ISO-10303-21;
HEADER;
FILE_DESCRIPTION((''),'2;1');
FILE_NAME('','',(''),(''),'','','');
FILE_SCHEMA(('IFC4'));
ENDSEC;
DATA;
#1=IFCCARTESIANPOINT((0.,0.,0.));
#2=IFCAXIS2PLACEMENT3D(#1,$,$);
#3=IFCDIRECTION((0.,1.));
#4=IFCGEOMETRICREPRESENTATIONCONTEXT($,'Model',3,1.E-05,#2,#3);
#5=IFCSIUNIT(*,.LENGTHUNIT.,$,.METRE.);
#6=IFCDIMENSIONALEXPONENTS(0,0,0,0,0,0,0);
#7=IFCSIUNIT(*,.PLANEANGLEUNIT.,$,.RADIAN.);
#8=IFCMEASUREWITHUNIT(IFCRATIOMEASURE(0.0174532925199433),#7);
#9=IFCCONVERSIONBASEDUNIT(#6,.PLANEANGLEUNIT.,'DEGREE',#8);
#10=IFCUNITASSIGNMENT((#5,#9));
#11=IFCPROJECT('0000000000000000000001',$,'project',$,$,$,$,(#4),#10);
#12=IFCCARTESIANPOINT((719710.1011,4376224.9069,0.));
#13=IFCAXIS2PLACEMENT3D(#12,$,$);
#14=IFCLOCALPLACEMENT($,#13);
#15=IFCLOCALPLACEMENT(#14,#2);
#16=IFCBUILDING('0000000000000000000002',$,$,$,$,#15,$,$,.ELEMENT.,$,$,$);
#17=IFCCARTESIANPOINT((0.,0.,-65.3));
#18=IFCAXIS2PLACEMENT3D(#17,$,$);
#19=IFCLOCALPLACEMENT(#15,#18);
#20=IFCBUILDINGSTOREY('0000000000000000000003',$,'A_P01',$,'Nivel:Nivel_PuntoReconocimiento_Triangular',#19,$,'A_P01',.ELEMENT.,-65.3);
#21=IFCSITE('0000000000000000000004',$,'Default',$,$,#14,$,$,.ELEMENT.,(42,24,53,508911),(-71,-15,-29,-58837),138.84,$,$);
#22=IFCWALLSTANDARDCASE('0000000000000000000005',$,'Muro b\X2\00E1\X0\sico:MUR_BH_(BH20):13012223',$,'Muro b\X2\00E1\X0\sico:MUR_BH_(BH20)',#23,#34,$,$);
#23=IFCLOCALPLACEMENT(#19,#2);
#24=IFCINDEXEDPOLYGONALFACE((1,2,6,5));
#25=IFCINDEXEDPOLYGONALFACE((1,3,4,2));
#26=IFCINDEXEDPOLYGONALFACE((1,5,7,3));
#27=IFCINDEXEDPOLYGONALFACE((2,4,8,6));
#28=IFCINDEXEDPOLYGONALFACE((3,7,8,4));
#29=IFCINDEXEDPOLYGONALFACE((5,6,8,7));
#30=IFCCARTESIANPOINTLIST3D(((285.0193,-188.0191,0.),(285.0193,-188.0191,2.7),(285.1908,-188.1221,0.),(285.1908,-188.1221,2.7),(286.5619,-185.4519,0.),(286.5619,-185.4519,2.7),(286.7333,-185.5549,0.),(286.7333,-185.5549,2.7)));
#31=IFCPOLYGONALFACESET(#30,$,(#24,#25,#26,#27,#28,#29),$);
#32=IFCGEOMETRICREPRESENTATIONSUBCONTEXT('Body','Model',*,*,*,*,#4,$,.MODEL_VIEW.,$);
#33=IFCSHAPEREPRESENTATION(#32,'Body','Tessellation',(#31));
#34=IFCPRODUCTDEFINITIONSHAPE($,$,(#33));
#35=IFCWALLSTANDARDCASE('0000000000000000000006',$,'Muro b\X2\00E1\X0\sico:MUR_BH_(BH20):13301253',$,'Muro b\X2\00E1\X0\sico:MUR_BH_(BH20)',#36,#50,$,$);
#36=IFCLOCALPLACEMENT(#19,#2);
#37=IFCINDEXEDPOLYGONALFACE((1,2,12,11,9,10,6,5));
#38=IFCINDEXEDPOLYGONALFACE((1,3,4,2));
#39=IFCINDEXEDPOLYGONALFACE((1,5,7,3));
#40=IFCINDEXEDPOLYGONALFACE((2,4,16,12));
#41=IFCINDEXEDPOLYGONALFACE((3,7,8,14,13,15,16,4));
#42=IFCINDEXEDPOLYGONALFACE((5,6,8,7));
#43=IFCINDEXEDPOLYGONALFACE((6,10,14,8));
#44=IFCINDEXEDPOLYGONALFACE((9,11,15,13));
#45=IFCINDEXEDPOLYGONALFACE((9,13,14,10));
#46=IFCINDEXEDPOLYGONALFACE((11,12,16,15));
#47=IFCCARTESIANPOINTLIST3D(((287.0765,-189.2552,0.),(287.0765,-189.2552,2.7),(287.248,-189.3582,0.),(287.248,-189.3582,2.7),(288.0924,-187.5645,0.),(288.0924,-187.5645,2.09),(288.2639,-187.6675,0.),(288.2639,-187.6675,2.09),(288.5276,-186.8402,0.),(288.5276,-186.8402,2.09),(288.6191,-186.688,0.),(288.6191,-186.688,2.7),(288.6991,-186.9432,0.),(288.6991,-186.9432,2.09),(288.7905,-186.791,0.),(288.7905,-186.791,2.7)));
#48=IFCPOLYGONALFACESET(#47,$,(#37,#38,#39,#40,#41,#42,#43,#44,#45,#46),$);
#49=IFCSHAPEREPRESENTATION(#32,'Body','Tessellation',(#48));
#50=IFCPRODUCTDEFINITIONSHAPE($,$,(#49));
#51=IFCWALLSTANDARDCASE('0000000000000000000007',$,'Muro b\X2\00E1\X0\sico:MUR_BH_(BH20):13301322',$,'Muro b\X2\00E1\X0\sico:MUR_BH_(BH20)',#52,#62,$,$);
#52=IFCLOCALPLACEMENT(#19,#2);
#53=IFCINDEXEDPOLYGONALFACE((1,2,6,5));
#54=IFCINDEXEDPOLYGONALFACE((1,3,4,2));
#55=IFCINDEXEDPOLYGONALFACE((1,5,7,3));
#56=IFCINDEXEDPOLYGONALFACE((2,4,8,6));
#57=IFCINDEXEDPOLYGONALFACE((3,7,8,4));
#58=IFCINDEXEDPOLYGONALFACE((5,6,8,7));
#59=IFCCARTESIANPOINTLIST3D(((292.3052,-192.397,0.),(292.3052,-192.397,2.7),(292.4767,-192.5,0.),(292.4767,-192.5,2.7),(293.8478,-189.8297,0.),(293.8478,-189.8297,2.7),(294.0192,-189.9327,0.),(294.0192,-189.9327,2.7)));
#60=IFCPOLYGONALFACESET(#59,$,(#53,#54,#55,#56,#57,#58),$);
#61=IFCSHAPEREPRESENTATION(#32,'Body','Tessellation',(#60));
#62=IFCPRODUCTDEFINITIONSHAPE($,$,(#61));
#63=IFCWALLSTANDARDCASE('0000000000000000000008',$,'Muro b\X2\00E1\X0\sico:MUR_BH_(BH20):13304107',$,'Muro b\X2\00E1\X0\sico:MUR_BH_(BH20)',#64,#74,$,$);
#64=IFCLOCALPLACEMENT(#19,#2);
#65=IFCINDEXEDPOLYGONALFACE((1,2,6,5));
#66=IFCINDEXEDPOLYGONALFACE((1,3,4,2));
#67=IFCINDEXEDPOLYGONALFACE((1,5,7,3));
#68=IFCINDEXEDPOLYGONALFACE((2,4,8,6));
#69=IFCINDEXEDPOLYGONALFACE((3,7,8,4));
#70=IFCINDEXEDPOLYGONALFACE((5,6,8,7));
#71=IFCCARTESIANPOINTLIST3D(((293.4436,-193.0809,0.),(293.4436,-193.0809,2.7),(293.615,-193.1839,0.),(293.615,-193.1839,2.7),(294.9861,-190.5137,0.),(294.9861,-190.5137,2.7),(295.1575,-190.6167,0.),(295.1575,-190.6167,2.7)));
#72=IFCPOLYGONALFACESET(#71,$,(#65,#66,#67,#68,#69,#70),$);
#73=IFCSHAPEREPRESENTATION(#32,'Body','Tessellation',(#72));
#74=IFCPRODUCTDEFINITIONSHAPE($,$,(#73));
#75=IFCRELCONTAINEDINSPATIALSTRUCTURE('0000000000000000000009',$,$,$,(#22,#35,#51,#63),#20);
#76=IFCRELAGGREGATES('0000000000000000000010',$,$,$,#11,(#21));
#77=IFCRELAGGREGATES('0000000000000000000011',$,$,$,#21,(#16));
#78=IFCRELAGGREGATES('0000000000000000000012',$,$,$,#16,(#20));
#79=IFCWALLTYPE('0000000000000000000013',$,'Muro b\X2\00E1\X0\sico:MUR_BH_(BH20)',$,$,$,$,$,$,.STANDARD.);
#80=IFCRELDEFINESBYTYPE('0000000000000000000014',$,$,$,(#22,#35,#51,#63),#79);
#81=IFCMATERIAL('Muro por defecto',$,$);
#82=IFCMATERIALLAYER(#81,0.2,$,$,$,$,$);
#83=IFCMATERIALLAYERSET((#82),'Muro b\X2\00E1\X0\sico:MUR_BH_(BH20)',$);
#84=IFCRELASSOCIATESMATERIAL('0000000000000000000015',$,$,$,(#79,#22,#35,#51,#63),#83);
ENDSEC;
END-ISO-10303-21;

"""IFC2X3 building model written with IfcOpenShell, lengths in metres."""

from ifc_helpers import new_model, entity, si_unit, converted_unit, direction, frame, frame_2d, origin, place, context, subcontext, project, spatial, rectangle, extrude, material, layer, layer_set, layer_usage, type_object, element, save


model = new_model("IFC2X3")

# Units and contexts
model_context = context("Model", 3, precision=1e-05, world=origin(), true_north=direction((0.0, 1.0)))
body_context = subcontext(model_context, "Body", "Model", "MODEL_VIEW")
ifc_project = project(units=[si_unit("LENGTHUNIT", "METRE"), converted_unit("PLANEANGLEUNIT", "DEGREE", entity("IfcRatioMeasure", 0.0174532925199433), si_unit("PLANEANGLEUNIT", "RADIAN"), dimensions=[0, 0, 0, 0, 0, 0, 0])], contexts=[model_context])

# Site, building, storey
site_placement = place(None, frame((719710.1011, 4376224.9069, 0.0)))
site = spatial("IfcSite", under=ifc_project, at=site_placement, Name="Default", CompositionType="ELEMENT", RefLatitude=(42, 24, 53, 508911), RefLongitude=(-71, -15, -29, -58837), RefElevation=138.84)
building_placement = place(site_placement, origin())
building = spatial("IfcBuilding", under=site, at=building_placement, CompositionType="ELEMENT")
storey_placement = place(building_placement, frame((0.0, 0.0, -65.3)))
storey = spatial("IfcBuildingStorey", under=building, at=storey_placement, Name="A_P01", ObjectType="Nivel:Nivel_PuntoReconocimiento_Triangular", LongName="A_P01", CompositionType="ELEMENT", Elevation=-65.3)

# Shared definitions
ifc_material_1 = material(Name="Muro por defecto")
ifc_layer = layer(ifc_material_1, 0.2)
ifc_layer_set = layer_set([ifc_layer], Name="Muro básico:MUR_BH_(BH20)")
wall_type = type_object("IfcWallType", Name="Muro básico:MUR_BH_(BH20)", PredefinedType="STANDARD", material=ifc_layer_set)

# Wall
ifc_layer_usage_1 = layer_usage(ifc_layer_set, "AXIS2", "NEGATIVE", 0.1)
wall_1_placement = place(storey_placement, frame((285.105, -188.0706, 0.0), z_axis=(0.0, 0.0, 1.0), x_axis=(0.515038, 0.857167, 0.0)))
element("IfcWallStandardCase", 1, at=wall_1_placement, inside=storey, type_object=wall_type, material=ifc_layer_usage_1, Name="Muro básico:MUR_BH_(BH20):13012223", ObjectType="Muro básico:MUR_BH_(BH20)", context=body_context, shape_type="SweptSolid", body=[
    extrude(rectangle(XDim=2.995, YDim=0.2, at=frame_2d((1.4975, 0.0), x_axis=(-1.0, 0.0))), origin(), (0.0, 0.0, 1.0), 2.7),
])

# Wall, opening
ifc_layer_usage_2 = layer_usage(ifc_layer_set, "AXIS2", "NEGATIVE", 0.1)
wall_2_placement = place(storey_placement, frame((287.1622, -189.3067, 0.0), z_axis=(0.0, 0.0, 1.0), x_axis=(0.515038, 0.857167, 0.0)))
wall_2 = element("IfcWallStandardCase", 2, at=wall_2_placement, inside=storey, type_object=wall_type, material=ifc_layer_usage_2, Name="Muro básico:MUR_BH_(BH20):13301253", ObjectType="Muro básico:MUR_BH_(BH20)", context=body_context, shape_type="SweptSolid", body=[
    extrude(rectangle(XDim=2.995, YDim=0.2, at=frame_2d((1.4975, 0.0), x_axis=(-1.0, 0.0))), origin(), (0.0, 0.0, 1.0), 2.7),
])
opening_1_placement = place(wall_2_placement, frame((14.368, 343.6462, 0.0), z_axis=(0.0, 0.0, 1.0), x_axis=(0.515038, -0.857167, 0.0)))
element("IfcOpeningElement", 3, at=opening_1_placement, cuts=wall_2, ObjectType="Opening", context=body_context, shape_type="SweptSolid", body=[
    extrude(rectangle(XDim=2.09, YDim=0.845, at=frame_2d((0.0, 0.0), x_axis=(1.0, 0.0))), frame((288.4815, -187.3053, 1.045), z_axis=(-0.857167, 0.515038, 0.0), x_axis=(0.0, 0.0, -1.0)), (0.0, 0.0, 1.0), 0.2),
])

# Walls
ifc_layer_usage_3 = layer_usage(ifc_layer_set, "AXIS2", "NEGATIVE", 0.1)
wall_3_placement = place(storey_placement, frame((293.9335, -189.8812, 0.0), z_axis=(0.0, 0.0, 1.0), x_axis=(-0.515038, -0.857167, 0.0)))
element("IfcWallStandardCase", 4, at=wall_3_placement, inside=storey, type_object=wall_type, material=ifc_layer_usage_3, Name="Muro básico:MUR_BH_(BH20):13301322", ObjectType="Muro básico:MUR_BH_(BH20)", context=body_context, shape_type="SweptSolid", body=[
    extrude(rectangle(XDim=2.995, YDim=0.2, at=frame_2d((1.4975, 0.0), x_axis=(-1.0, 0.0))), origin(), (0.0, 0.0, 1.0), 2.7),
])
ifc_layer_usage_4 = layer_usage(ifc_layer_set, "AXIS2", "NEGATIVE", 0.1)
wall_4_placement = place(storey_placement, frame((295.0718, -190.5652, 0.0), z_axis=(0.0, 0.0, 1.0), x_axis=(-0.515038, -0.857167, 0.0)))
element("IfcWallStandardCase", 5, at=wall_4_placement, inside=storey, type_object=wall_type, material=ifc_layer_usage_4, Name="Muro básico:MUR_BH_(BH20):13304107", ObjectType="Muro básico:MUR_BH_(BH20)", context=body_context, shape_type="SweptSolid", body=[
    extrude(rectangle(XDim=2.995, YDim=0.2, at=frame_2d((1.4975, 0.0), x_axis=(-1.0, 0.0))), origin(), (0.0, 0.0, 1.0), 2.7),
])

save(model, "model.ifc")
